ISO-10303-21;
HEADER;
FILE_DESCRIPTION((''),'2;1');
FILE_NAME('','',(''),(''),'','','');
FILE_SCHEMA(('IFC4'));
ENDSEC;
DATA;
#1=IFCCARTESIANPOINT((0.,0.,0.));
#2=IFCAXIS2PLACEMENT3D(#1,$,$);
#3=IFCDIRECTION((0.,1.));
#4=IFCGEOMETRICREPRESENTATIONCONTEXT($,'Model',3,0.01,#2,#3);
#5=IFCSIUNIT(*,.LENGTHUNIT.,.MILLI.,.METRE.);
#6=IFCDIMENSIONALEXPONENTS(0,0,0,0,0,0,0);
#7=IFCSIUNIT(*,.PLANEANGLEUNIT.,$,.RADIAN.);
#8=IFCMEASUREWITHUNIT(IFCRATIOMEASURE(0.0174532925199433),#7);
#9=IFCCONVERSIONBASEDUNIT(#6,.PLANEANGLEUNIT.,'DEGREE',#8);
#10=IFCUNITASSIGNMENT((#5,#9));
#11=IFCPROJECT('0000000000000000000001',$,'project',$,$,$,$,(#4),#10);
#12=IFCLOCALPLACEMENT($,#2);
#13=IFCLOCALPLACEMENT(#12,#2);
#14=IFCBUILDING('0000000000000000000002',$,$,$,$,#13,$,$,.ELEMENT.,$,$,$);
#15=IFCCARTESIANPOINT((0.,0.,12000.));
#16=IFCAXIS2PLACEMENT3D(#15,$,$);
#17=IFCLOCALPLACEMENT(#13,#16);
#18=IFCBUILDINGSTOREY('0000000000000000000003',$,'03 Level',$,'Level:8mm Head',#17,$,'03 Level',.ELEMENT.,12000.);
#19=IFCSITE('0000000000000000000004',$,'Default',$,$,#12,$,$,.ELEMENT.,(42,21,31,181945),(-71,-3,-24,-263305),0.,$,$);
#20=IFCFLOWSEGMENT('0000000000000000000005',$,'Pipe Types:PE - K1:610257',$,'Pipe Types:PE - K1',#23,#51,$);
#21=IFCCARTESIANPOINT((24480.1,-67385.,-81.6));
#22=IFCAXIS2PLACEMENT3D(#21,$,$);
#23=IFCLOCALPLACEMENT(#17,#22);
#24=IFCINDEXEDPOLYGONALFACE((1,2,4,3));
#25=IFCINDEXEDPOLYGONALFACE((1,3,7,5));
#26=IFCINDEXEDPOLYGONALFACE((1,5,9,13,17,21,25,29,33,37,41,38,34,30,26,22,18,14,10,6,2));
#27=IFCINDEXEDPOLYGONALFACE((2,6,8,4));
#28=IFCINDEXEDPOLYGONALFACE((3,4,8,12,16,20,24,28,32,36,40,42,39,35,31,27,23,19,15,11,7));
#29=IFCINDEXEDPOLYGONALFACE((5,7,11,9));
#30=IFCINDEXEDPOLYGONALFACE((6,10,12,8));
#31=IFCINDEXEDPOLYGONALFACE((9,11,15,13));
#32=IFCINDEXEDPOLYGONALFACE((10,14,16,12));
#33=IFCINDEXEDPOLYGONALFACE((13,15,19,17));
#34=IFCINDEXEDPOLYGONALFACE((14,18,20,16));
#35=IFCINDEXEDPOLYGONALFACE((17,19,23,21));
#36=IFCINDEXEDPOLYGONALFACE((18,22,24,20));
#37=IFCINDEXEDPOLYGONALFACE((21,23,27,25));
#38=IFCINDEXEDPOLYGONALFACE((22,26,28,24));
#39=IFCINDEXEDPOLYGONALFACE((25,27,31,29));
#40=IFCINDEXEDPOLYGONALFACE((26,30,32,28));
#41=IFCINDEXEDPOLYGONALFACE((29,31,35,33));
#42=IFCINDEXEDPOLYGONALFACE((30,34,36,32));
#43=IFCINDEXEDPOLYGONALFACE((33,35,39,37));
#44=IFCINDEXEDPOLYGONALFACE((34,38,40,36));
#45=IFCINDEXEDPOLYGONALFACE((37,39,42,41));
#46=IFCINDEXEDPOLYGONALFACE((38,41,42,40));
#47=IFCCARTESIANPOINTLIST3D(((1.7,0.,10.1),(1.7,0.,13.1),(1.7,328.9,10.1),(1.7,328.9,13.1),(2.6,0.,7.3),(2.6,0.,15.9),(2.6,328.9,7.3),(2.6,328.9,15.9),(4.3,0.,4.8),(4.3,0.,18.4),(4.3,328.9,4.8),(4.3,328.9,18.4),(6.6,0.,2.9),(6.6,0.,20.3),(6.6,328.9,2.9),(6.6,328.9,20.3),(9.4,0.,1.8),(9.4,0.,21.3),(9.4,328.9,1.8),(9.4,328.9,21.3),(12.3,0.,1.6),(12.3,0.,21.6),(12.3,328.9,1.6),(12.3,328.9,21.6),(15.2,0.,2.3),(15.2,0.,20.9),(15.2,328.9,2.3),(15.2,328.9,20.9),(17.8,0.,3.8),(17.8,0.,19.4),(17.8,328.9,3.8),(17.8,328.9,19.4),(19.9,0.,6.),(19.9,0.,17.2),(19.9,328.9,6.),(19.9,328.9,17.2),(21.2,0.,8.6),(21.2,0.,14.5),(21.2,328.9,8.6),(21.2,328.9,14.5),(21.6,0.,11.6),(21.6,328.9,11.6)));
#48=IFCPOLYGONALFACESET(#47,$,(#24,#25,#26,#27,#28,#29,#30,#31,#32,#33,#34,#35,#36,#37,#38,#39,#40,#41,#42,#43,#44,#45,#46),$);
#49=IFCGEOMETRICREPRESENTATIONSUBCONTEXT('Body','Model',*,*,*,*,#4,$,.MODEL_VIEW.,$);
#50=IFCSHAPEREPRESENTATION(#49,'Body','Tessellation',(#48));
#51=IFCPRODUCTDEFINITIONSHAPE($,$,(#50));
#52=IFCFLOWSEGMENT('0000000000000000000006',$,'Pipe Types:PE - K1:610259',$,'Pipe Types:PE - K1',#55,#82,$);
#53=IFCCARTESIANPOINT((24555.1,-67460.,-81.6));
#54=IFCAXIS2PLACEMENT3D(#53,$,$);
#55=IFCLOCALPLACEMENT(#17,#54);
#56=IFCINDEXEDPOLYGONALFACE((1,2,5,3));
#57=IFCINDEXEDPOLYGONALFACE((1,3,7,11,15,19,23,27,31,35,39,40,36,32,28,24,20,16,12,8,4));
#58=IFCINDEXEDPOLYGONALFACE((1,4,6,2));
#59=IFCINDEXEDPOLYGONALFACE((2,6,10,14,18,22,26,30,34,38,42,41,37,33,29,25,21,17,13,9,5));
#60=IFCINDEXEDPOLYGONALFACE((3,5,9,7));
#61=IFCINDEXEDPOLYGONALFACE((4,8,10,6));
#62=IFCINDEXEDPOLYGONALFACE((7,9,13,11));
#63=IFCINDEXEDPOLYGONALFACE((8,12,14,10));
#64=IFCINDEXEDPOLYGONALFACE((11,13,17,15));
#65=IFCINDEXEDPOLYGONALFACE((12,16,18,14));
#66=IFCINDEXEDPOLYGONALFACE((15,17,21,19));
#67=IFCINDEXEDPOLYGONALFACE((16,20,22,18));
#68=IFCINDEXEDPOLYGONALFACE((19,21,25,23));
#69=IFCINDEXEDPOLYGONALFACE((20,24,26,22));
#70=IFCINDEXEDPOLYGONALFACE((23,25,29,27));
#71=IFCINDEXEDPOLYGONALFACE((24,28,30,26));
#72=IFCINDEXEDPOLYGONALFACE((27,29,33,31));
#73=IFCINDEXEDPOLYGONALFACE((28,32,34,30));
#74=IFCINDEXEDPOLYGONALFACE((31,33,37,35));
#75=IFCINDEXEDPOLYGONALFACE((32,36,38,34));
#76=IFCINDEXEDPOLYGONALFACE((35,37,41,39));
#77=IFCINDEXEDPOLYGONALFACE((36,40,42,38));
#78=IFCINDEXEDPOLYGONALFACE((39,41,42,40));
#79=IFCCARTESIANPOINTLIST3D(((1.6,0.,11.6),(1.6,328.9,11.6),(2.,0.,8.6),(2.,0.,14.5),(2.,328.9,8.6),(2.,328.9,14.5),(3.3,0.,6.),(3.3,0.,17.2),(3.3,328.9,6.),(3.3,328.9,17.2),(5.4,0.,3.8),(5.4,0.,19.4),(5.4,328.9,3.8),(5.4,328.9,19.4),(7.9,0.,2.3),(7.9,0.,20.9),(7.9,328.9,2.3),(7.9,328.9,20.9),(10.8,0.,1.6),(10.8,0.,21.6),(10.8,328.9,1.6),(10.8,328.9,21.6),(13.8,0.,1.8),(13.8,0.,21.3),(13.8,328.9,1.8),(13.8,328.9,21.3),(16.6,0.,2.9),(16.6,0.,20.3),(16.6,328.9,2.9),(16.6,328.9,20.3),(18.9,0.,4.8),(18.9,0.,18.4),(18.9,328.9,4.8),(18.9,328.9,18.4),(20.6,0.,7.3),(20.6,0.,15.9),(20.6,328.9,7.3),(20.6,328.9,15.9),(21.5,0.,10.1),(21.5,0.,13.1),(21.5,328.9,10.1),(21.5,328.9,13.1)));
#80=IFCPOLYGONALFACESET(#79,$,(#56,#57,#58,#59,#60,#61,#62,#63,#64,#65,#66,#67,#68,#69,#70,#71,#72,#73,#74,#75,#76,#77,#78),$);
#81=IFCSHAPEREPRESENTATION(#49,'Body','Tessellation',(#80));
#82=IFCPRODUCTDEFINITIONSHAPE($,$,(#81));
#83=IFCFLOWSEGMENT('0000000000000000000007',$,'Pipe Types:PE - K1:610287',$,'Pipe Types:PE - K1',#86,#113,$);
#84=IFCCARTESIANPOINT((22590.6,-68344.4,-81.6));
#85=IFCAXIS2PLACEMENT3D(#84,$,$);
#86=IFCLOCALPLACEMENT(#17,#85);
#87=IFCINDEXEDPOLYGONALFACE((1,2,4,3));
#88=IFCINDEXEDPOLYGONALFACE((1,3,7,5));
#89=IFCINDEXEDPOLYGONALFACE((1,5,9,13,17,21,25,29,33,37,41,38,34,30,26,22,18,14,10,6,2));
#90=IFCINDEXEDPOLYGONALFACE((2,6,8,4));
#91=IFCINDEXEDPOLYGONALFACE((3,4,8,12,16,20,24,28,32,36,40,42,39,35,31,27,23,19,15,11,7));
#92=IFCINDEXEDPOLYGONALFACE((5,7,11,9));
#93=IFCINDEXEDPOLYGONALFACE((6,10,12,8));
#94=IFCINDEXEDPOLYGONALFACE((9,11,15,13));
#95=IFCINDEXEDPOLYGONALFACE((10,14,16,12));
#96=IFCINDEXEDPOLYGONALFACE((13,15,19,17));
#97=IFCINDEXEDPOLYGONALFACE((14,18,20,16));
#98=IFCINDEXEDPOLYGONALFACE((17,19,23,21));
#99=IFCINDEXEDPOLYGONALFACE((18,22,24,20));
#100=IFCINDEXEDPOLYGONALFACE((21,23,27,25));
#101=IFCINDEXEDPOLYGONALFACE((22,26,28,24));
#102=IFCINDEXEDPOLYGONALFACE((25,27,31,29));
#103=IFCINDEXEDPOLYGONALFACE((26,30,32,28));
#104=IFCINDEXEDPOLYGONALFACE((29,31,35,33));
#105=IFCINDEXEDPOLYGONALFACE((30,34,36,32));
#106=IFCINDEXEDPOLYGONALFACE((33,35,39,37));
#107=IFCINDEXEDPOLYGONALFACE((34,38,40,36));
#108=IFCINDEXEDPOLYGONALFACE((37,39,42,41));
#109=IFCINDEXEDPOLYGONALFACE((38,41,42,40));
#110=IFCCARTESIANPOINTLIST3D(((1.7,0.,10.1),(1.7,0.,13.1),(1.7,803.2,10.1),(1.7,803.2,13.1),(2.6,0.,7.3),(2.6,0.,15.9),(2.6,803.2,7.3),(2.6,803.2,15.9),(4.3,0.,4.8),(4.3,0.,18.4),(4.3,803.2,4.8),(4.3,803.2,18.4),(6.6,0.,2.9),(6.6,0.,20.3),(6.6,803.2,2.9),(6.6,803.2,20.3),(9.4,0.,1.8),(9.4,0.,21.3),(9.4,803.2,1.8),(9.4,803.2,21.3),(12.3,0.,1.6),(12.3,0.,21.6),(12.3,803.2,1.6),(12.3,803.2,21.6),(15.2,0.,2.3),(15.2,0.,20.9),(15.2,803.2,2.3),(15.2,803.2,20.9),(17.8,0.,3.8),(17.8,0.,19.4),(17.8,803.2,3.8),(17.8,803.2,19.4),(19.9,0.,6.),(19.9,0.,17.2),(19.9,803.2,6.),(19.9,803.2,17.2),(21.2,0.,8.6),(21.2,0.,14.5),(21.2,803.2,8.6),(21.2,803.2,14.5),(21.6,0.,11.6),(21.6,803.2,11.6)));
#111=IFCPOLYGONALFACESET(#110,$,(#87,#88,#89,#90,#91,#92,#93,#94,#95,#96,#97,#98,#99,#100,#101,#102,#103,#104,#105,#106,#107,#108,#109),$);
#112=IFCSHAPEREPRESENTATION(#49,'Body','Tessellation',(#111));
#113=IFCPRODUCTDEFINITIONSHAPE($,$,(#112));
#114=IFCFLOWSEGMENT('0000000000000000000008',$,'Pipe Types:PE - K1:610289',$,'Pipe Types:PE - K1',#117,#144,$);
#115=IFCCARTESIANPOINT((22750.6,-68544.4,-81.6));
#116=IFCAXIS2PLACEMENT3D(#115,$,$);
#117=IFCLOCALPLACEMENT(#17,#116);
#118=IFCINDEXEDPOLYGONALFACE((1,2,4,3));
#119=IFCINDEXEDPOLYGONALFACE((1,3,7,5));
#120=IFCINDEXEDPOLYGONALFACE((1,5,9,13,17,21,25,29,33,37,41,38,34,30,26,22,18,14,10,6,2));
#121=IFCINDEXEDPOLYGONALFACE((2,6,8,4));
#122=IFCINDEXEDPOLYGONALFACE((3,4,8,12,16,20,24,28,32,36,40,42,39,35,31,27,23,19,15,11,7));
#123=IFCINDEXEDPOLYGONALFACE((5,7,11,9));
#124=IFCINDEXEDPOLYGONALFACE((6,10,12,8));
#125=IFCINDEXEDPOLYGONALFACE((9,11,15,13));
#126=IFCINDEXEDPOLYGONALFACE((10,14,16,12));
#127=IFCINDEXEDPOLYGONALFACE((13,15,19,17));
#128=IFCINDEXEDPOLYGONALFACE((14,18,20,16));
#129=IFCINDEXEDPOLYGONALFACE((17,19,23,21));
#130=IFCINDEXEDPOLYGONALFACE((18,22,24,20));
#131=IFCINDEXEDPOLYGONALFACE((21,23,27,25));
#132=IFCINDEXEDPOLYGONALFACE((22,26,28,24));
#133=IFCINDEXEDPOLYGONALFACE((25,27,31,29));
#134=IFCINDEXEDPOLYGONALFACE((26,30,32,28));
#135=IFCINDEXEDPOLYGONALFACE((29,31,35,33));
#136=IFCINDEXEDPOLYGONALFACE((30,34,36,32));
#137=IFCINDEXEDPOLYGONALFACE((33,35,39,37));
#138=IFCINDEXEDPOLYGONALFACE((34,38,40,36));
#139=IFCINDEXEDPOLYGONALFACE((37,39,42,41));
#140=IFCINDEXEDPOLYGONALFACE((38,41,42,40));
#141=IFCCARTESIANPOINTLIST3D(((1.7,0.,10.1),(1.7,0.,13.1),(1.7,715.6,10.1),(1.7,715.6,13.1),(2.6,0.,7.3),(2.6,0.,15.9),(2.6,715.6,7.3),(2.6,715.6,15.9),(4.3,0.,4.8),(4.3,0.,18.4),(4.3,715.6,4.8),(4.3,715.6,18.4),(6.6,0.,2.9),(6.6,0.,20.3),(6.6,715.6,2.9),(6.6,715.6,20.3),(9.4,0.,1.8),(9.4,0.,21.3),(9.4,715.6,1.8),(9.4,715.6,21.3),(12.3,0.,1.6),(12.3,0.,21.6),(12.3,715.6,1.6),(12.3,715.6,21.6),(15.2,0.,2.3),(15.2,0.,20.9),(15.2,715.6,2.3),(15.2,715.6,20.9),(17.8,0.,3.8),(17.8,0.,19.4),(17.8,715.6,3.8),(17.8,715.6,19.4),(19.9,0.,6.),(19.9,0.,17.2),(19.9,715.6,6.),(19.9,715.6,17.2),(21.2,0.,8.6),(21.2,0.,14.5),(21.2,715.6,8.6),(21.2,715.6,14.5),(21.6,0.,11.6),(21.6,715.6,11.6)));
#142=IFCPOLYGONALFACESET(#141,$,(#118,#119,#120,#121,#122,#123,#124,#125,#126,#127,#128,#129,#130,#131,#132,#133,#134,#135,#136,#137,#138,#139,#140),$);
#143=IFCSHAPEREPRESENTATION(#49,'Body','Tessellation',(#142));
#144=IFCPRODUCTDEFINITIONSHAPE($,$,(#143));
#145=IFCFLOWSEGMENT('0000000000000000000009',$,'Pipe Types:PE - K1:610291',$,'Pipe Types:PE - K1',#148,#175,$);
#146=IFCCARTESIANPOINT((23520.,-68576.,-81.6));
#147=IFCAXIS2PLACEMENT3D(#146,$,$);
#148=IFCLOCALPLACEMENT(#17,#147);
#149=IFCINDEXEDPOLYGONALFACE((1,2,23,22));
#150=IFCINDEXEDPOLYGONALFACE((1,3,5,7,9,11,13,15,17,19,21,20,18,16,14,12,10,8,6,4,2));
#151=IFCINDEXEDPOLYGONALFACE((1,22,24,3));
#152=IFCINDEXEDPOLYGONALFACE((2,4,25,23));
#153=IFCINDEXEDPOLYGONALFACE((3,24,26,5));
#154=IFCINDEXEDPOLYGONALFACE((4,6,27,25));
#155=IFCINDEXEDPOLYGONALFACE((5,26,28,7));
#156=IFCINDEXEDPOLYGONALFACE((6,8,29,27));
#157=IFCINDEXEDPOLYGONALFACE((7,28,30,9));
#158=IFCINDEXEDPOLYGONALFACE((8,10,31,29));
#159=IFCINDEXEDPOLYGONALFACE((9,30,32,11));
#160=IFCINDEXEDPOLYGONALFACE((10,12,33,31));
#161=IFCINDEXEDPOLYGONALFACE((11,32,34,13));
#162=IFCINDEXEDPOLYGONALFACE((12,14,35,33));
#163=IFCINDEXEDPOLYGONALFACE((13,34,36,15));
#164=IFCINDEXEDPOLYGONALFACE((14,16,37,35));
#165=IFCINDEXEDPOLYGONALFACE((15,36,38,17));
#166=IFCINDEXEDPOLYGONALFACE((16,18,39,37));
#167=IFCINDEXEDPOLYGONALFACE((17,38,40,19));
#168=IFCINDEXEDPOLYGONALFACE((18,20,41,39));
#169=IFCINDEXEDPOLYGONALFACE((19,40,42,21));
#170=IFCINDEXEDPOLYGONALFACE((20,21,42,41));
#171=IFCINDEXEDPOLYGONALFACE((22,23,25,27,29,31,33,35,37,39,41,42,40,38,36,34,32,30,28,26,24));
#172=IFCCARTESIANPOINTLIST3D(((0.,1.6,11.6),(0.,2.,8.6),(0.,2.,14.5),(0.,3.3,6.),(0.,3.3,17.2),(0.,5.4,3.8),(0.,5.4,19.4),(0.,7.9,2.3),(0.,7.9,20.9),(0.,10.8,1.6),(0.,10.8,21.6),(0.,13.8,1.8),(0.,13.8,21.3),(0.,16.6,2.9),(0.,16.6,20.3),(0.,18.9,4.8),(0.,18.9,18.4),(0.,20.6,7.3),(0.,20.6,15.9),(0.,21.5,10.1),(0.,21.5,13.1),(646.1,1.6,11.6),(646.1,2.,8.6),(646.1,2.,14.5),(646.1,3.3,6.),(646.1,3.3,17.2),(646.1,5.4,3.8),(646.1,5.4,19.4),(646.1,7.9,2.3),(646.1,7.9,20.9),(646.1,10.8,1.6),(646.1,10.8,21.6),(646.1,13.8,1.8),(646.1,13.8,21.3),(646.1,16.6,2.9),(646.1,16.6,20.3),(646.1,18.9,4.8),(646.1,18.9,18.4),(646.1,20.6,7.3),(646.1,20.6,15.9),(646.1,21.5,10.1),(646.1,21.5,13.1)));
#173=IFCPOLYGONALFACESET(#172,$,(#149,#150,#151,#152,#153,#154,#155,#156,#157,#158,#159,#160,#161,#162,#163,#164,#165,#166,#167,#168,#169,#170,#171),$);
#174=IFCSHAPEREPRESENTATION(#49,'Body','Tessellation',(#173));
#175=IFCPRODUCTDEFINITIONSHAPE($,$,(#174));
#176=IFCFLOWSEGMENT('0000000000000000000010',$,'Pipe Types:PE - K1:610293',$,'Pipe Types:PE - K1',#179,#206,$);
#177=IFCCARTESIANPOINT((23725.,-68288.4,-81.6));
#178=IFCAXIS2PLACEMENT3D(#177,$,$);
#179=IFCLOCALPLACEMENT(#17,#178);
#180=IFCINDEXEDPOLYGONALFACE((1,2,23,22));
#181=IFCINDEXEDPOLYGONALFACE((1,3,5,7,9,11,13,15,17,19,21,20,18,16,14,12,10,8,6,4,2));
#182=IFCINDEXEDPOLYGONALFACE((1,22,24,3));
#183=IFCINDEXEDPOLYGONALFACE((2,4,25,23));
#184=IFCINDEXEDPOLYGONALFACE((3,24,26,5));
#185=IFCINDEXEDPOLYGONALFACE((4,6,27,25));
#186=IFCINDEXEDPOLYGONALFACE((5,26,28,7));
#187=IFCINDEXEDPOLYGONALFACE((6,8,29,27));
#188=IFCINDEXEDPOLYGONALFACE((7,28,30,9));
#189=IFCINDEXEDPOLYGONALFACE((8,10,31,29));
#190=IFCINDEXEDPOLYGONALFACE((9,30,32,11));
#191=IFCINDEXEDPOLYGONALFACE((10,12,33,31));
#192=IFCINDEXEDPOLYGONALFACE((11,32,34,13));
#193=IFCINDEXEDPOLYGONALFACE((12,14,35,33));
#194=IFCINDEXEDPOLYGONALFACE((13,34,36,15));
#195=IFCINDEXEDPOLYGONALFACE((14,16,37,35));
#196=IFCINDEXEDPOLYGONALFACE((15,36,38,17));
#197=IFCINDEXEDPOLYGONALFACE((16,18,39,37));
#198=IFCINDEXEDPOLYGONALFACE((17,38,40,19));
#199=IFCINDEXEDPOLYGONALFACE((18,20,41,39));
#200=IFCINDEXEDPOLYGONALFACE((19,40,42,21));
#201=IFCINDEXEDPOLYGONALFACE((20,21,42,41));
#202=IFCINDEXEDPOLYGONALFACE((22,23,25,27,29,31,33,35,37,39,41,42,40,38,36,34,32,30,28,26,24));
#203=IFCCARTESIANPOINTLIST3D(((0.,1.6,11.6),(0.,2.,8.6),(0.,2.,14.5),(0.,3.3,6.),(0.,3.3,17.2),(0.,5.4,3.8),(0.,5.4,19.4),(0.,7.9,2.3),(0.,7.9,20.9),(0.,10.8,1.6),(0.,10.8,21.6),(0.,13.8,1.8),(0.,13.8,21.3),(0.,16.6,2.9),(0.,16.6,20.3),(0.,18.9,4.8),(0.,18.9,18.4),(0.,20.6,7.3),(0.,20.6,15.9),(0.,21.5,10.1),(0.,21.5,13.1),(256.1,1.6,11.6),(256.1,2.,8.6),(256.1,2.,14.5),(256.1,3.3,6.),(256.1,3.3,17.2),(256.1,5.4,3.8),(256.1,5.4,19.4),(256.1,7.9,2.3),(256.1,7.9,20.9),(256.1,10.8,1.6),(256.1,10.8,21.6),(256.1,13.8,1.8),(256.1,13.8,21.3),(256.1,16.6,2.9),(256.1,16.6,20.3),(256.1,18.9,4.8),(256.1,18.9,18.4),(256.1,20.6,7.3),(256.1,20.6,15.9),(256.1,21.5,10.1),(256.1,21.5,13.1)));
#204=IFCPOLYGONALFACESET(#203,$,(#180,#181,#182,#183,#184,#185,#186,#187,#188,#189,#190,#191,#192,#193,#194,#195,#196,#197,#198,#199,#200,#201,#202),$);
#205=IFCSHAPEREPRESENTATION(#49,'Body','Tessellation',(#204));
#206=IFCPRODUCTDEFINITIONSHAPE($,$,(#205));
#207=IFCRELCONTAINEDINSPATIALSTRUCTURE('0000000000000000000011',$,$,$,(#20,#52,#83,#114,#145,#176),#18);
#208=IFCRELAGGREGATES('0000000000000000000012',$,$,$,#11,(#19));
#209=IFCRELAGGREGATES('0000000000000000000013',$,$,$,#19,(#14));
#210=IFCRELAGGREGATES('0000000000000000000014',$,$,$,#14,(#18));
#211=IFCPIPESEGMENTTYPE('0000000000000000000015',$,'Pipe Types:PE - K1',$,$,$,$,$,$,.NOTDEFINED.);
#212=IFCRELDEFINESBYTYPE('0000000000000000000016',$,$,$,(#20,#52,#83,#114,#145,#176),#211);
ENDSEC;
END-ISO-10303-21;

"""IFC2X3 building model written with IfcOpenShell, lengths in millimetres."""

from ifc_helpers import new_model, entity, si_unit, converted_unit, direction, frame, frame_2d, origin, origin_2d_with_axis, place, context, subcontext, project, spatial, circle, extrude, type_object, element, save


model = new_model("IFC2X3")

# Units and contexts
model_context = context("Model", 3, precision=0.01, world=origin(), true_north=direction((0.0, 1.0)))
body_context = subcontext(model_context, "Body", "Model", "MODEL_VIEW")
ifc_project = project(units=[si_unit("LENGTHUNIT", "METRE", prefix="MILLI"), converted_unit("PLANEANGLEUNIT", "DEGREE", entity("IfcRatioMeasure", 0.0174532925199433), si_unit("PLANEANGLEUNIT", "RADIAN"), dimensions=[0, 0, 0, 0, 0, 0, 0])], contexts=[model_context])

# Site, building, storey
site_placement = place(None, origin())
site = spatial("IfcSite", under=ifc_project, at=site_placement, Name="Default", CompositionType="ELEMENT", RefLatitude=(42, 21, 31, 181945), RefLongitude=(-71, -3, -24, -263305), RefElevation=0.0)
building_placement = place(site_placement, origin())
building = spatial("IfcBuilding", under=site, at=building_placement, CompositionType="ELEMENT")
storey_placement = place(building_placement, frame((0.0, 0.0, 12000.0)))
storey = spatial("IfcBuildingStorey", under=building, at=storey_placement, Name="03 Level", ObjectType="Level:8mm Head", LongName="03 Level", CompositionType="ELEMENT", Elevation=12000.0)

# Flow segments
pipe_segment_type = type_object("IfcPipeSegmentType", Name="Pipe Types:PE - K1", PredefinedType="NOTDEFINED")
flow_segment_1_placement = place(storey_placement, frame((24480.1, -67385.0, -81.6)))
element("IfcFlowSegment", 1, at=flow_segment_1_placement, inside=storey, type_object=pipe_segment_type, Name="Pipe Types:PE - K1:610257", ObjectType="Pipe Types:PE - K1", context=body_context, shape_type="SweptSolid", body=[
    extrude(circle(Radius=10.0, at=origin_2d_with_axis()), frame((11.6, 0.0, 11.6), z_axis=(0.0, 1.0, 0.0), x_axis=(1.0, 0.0, 0.0)), (0.0, 0.0, 1.0), 328.9),
])
flow_segment_2_placement = place(storey_placement, frame((24555.1, -67460.0, -81.6)))
element("IfcFlowSegment", 2, at=flow_segment_2_placement, inside=storey, type_object=pipe_segment_type, Name="Pipe Types:PE - K1:610259", ObjectType="Pipe Types:PE - K1", context=body_context, shape_type="SweptSolid", body=[
    extrude(circle(Radius=10.0, at=frame_2d((0.0, 0.0), x_axis=(1.0, 0.0))), frame((11.6, 0.0, 11.6), z_axis=(0.0, 1.0, 0.0), x_axis=(-1.0, 0.0, 0.0)), (0.0, 0.0, 1.0), 328.9),
])
flow_segment_3_placement = place(storey_placement, frame((22590.6, -68344.4, -81.6)))
element("IfcFlowSegment", 3, at=flow_segment_3_placement, inside=storey, type_object=pipe_segment_type, Name="Pipe Types:PE - K1:610287", ObjectType="Pipe Types:PE - K1", context=body_context, shape_type="SweptSolid", body=[
    extrude(circle(Radius=10.0, at=origin_2d_with_axis()), frame((11.6, 0.0, 11.6), z_axis=(0.0, 1.0, 0.0), x_axis=(1.0, 0.0, 0.0)), (0.0, 0.0, 1.0), 803.2),
])
flow_segment_4_placement = place(storey_placement, frame((22750.6, -68544.4, -81.6)))
element("IfcFlowSegment", 4, at=flow_segment_4_placement, inside=storey, type_object=pipe_segment_type, Name="Pipe Types:PE - K1:610289", ObjectType="Pipe Types:PE - K1", context=body_context, shape_type="SweptSolid", body=[
    extrude(circle(Radius=10.0, at=origin_2d_with_axis()), frame((11.6, 0.0, 11.6), z_axis=(0.0, 1.0, 0.0), x_axis=(1.0, 0.0, 0.0)), (0.0, 0.0, 1.0), 715.6),
])
flow_segment_5_placement = place(storey_placement, frame((23520.0, -68576.0, -81.6)))
element("IfcFlowSegment", 5, at=flow_segment_5_placement, inside=storey, type_object=pipe_segment_type, Name="Pipe Types:PE - K1:610291", ObjectType="Pipe Types:PE - K1", context=body_context, shape_type="SweptSolid", body=[
    extrude(circle(Radius=10.0, at=origin_2d_with_axis()), frame((0.0, 11.6, 11.6), z_axis=(1.0, 0.0, 0.0), x_axis=(0.0, -1.0, 0.0)), (0.0, 0.0, 1.0), 646.1),
])
flow_segment_6_placement = place(storey_placement, frame((23725.0, -68288.4, -81.6)))
element("IfcFlowSegment", 6, at=flow_segment_6_placement, inside=storey, type_object=pipe_segment_type, Name="Pipe Types:PE - K1:610293", ObjectType="Pipe Types:PE - K1", context=body_context, shape_type="SweptSolid", body=[
    extrude(circle(Radius=10.0, at=frame_2d((0.0, 0.0), x_axis=(1.0, 0.0))), frame((0.0, 11.6, 11.6), z_axis=(1.0, 0.0, 0.0), x_axis=(0.0, -1.0, 0.0)), (0.0, 0.0, 1.0), 256.1),
])

save(model, "model.ifc")
